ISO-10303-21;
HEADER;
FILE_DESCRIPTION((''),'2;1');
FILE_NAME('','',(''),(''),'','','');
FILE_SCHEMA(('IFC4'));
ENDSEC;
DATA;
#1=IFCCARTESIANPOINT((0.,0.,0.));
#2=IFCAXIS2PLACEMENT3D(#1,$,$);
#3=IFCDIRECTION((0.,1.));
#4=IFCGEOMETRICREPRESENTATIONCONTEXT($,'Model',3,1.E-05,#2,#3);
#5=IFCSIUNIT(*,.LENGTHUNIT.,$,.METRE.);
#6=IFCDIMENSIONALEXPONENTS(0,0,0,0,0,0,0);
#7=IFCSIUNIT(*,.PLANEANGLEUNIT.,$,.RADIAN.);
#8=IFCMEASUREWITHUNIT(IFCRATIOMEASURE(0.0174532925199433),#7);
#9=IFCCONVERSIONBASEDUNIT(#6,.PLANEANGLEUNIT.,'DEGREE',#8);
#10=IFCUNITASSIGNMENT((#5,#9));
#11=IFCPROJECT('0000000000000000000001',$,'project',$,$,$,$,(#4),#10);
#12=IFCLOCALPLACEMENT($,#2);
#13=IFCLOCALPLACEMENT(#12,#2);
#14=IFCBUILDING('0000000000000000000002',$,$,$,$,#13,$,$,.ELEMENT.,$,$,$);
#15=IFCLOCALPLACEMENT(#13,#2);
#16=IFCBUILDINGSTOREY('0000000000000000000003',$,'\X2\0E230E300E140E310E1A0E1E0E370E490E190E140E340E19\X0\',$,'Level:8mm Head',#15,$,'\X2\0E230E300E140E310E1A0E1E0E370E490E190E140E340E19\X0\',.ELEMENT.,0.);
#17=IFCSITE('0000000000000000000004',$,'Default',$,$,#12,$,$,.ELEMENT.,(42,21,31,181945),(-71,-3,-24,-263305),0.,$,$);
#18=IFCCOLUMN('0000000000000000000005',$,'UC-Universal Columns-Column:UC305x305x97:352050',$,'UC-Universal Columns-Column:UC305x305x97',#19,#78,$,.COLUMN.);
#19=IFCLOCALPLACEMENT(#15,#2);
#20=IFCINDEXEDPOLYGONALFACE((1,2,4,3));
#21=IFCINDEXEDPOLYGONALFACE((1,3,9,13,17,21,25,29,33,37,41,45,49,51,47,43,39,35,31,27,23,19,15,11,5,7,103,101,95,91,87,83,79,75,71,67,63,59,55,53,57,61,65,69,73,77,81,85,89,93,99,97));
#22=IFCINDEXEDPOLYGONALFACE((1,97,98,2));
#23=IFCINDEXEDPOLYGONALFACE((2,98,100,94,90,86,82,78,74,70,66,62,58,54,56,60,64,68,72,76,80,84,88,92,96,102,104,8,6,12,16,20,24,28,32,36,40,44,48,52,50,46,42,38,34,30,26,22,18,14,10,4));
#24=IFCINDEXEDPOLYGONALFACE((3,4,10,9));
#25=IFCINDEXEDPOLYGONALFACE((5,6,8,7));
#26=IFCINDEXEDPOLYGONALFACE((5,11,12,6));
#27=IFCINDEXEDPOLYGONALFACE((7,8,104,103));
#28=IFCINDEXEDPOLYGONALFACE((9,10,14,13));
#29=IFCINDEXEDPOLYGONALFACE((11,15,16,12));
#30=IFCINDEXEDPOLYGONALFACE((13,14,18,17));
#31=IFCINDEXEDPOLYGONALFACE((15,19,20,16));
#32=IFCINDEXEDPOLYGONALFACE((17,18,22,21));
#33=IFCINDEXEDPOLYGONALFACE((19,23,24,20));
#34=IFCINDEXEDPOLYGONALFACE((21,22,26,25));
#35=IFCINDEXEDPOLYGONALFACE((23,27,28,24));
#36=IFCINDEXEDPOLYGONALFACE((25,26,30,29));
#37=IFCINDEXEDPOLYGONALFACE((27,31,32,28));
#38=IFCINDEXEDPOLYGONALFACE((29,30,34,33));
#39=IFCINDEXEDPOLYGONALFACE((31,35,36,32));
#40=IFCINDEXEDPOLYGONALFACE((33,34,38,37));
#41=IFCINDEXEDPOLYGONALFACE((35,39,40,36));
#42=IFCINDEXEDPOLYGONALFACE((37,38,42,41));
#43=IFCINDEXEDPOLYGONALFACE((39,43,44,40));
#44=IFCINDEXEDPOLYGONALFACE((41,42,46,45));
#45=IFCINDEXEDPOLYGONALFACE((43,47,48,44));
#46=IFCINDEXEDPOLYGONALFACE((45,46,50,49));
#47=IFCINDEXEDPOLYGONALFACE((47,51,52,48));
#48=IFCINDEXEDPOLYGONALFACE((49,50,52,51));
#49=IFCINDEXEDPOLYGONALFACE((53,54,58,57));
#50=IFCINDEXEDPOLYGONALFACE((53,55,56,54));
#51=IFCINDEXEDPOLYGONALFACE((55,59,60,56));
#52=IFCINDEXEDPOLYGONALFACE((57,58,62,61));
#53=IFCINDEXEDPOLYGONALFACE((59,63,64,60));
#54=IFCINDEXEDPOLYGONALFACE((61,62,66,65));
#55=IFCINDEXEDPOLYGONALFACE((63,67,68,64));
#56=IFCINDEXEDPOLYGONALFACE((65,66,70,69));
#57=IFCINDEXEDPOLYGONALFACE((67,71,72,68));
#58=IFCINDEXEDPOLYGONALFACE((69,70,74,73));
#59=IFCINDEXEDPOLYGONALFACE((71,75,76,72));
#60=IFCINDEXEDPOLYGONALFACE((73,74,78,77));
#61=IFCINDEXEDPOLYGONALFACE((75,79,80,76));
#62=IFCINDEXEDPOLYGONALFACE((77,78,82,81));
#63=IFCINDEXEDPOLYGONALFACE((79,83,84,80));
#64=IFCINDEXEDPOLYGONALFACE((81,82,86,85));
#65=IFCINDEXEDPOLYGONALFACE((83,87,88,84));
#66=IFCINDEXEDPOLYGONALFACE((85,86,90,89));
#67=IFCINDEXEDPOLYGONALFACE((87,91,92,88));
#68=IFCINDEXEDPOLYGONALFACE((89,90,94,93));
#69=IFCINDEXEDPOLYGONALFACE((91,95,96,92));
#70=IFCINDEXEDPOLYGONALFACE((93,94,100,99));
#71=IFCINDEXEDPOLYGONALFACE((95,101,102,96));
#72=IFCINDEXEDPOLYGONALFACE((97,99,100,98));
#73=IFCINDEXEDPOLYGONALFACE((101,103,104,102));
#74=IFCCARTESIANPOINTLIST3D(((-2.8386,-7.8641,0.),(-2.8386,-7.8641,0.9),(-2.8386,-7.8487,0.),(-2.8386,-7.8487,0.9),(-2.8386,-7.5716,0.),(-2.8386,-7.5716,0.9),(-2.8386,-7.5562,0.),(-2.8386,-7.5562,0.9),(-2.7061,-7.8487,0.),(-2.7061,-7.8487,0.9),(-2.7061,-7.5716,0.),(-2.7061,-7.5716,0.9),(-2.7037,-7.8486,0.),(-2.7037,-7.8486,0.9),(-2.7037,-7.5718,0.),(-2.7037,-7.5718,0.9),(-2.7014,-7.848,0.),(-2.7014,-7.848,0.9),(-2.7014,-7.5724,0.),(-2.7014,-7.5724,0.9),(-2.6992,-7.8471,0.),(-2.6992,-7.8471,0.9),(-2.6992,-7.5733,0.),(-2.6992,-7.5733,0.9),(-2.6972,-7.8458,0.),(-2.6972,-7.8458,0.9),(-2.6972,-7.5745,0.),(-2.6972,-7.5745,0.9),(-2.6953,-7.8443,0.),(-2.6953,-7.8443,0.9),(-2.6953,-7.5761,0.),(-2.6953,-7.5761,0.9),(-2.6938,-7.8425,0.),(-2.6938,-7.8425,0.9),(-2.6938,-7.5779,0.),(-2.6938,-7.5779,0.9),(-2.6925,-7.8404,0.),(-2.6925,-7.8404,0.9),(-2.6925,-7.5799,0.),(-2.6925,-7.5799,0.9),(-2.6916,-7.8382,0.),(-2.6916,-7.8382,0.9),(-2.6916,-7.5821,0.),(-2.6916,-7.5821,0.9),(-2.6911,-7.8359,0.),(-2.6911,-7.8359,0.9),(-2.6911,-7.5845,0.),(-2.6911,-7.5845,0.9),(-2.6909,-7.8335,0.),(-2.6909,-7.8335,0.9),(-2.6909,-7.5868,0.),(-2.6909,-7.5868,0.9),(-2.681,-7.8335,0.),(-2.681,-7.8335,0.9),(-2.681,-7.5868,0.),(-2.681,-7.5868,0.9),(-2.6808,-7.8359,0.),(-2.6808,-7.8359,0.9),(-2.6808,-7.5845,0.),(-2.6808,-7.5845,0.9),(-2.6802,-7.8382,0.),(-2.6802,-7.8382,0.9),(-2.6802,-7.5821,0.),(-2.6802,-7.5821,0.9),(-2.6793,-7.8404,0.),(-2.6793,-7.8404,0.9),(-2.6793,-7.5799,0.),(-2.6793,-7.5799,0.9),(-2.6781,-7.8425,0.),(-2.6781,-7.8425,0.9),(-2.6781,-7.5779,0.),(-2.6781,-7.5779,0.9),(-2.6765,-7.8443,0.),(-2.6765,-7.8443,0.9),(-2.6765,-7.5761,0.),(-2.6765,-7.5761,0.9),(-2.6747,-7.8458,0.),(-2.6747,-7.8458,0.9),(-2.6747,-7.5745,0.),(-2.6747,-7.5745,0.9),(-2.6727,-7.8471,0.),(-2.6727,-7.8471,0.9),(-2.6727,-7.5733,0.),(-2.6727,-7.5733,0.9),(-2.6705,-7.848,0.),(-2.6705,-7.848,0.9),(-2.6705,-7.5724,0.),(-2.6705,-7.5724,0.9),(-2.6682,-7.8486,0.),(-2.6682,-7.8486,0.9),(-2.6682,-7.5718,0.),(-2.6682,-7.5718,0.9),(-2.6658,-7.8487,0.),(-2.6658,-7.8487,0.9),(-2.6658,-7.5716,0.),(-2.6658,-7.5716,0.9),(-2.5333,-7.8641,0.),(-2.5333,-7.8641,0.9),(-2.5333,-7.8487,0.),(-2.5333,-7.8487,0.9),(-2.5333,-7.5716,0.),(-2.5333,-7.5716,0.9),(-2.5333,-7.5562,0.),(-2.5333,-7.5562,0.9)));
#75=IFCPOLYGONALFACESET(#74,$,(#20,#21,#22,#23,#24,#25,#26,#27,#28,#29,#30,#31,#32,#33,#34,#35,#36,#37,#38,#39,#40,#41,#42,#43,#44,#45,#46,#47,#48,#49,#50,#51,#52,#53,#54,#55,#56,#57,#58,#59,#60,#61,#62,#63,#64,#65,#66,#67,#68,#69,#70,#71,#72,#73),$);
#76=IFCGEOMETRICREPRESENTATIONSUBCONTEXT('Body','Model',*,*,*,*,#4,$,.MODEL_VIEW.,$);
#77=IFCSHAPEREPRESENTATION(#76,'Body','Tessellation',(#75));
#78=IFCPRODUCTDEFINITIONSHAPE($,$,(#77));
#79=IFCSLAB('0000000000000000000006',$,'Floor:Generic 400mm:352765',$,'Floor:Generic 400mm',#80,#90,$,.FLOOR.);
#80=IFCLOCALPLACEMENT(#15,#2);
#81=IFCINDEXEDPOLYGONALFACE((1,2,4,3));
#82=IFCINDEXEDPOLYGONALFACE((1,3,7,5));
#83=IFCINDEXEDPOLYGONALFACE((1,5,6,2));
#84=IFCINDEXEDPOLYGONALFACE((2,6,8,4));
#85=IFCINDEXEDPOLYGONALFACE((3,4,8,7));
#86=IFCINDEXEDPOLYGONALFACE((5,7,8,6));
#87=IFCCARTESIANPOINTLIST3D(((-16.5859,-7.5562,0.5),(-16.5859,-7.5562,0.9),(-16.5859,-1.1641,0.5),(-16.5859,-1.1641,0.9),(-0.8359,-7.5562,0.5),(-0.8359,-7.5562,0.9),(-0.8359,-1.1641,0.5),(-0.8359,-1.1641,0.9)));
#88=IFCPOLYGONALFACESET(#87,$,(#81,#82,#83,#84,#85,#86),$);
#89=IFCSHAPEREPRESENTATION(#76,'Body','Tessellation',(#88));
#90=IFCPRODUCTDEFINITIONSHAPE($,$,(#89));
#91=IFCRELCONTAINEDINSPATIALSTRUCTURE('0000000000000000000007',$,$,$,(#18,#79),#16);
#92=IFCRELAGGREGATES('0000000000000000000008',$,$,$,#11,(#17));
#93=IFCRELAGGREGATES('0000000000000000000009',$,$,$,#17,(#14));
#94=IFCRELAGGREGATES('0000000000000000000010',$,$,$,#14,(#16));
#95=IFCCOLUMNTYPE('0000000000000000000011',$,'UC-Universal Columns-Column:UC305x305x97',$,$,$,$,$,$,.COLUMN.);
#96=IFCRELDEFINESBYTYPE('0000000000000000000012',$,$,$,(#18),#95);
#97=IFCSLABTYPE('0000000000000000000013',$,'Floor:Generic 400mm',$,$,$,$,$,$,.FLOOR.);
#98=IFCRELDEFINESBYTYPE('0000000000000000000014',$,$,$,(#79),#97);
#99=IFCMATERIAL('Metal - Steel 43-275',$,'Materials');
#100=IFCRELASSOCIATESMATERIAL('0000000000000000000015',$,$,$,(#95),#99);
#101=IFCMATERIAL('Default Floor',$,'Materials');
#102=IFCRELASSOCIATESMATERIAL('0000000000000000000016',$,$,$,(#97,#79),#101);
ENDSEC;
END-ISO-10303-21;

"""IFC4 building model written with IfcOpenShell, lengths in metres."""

from ifc_helpers import new_model, entity, si_unit, converted_unit, direction, frame, origin, place, context, subcontext, project, spatial, indexed_curve, outline, extrude, source, transform, mapped, material, type_object, type_shapes, element, save


model = new_model("IFC4")

# Units and contexts
model_context = context("Model", 3, precision=1e-05, world=origin(), true_north=direction((0.0, 1.0)))
body_context = subcontext(model_context, "Body", "Model", "MODEL_VIEW")
ifc_project = project(units=[si_unit("LENGTHUNIT", "METRE"), converted_unit("PLANEANGLEUNIT", "DEGREE", entity("IfcRatioMeasure", 0.0174532925199433), si_unit("PLANEANGLEUNIT", "RADIAN"), dimensions=[0, 0, 0, 0, 0, 0, 0])], contexts=[model_context])

# Site, building, storey
site_placement = place(None, origin())
site = spatial("IfcSite", under=ifc_project, at=site_placement, Name="Default", CompositionType="ELEMENT", RefLatitude=(42, 21, 31, 181945), RefLongitude=(-71, -3, -24, -263305), RefElevation=0.0)
building_placement = place(site_placement, origin())
building = spatial("IfcBuilding", under=site, at=building_placement, CompositionType="ELEMENT")
storey_placement = place(building_placement, origin())
storey = spatial("IfcBuildingStorey", under=building, at=storey_placement, Name="ระดับพื้นดิน", ObjectType="Level:8mm Head", LongName="ระดับพื้นดิน", CompositionType="ELEMENT", Elevation=0.0)

# Column
ifc_material_1 = material(Name="Metal - Steel 43-275", Category="Materials")
column_type_1 = type_object("IfcColumnType", Name="UC-Universal Columns-Column:UC305x305x97", PredefinedType="COLUMN", material=ifc_material_1)
shared_shape_1 = source(origin(), body_context, "Body", "SweptSolid", [
    extrude(outline(indexed_curve([(-0.154, -0.1527), (-0.1386, -0.1527), (-0.1386, -0.0202), (-0.1384, -0.0178), (-0.1378, -0.0155), (-0.1369, -0.0132), (-0.1356, -0.0112), (-0.1341, -0.0094), (-0.1323, -0.0079), (-0.1303, -0.0066), (-0.128, -0.0057), (-0.1257, -0.0051), (-0.1234, -0.0049), (0.1234, -0.0049), (0.1257, -0.0051), (0.128, -0.0057), (0.1303, -0.0066), (0.1323, -0.0079), (0.1341, -0.0094), (0.1356, -0.0112), (0.1369, -0.0132), (0.1378, -0.0155), (0.1384, -0.0178), (0.1386, -0.0201), (0.1386, -0.1527), (0.154, -0.1527), (0.154, 0.1527), (0.1386, 0.1527), (0.1386, 0.0202), (0.1384, 0.0178), (0.1378, 0.0155), (0.1369, 0.0132), (0.1356, 0.0112), (0.1341, 0.0094), (0.1323, 0.0079), (0.1303, 0.0066), (0.128, 0.0057), (0.1257, 0.0051), (0.1234, 0.005), (-0.1234, 0.005), (-0.1257, 0.0051), (-0.128, 0.0057), (-0.1303, 0.0066), (-0.1323, 0.0079), (-0.1341, 0.0094), (-0.1356, 0.0112), (-0.1369, 0.0132), (-0.1378, 0.0155), (-0.1384, 0.0178), (-0.1386, 0.0202), (-0.1386, 0.1527), (-0.154, 0.1527), (-0.154, -0.1527)], self_intersect=False)), frame((0.0, 0.0, 0.0), z_axis=(0.0, 0.0, 1.0), x_axis=(0.0, -1.0, 0.0)), (0.0, 0.0, 1.0), 0.9),
])
type_shapes(column_type_1, [shared_shape_1])
for number, where, name in (
    (1, (-2.6859, -7.7102, 0.0), "UC-Universal Columns-Column:UC305x305x97:352050"),
):
    element("IfcColumn", number, at=place(storey_placement, frame(where)), inside=storey, type_object=column_type_1, Name=name, ObjectType="UC-Universal Columns-Column:UC305x305x97", PredefinedType="COLUMN", context=body_context, shape_type="MappedRepresentation", body=[
        mapped(shared_shape_1, transform((0.0, 0.0, 0.0), scale=1.0)),
    ])

# Slab
ifc_material_2 = material(Name="Default Floor", Category="Materials")
slab_type = type_object("IfcSlabType", Name="Floor:Generic 400mm", PredefinedType="FLOOR", material=ifc_material_2)
slab_placement = place(storey_placement, origin())
element("IfcSlab", 2, at=slab_placement, inside=storey, type_object=slab_type, material=ifc_material_2, Name="Floor:Generic 400mm:352765", ObjectType="Floor:Generic 400mm", PredefinedType="FLOOR", context=body_context, shape_type="SweptSolid", body=[
    extrude(outline(indexed_curve([(-3.1961, -7.875), (3.1961, -7.875), (3.1961, 7.875), (-3.1961, 7.875), (-3.1961, -7.875)], self_intersect=False)), frame((-8.7109, -4.3602, 0.9), z_axis=(0.0, 0.0, -1.0), x_axis=(0.0, 1.0, 0.0)), (0.0, 0.0, 1.0), 0.4),
])

save(model, "model.ifc")
